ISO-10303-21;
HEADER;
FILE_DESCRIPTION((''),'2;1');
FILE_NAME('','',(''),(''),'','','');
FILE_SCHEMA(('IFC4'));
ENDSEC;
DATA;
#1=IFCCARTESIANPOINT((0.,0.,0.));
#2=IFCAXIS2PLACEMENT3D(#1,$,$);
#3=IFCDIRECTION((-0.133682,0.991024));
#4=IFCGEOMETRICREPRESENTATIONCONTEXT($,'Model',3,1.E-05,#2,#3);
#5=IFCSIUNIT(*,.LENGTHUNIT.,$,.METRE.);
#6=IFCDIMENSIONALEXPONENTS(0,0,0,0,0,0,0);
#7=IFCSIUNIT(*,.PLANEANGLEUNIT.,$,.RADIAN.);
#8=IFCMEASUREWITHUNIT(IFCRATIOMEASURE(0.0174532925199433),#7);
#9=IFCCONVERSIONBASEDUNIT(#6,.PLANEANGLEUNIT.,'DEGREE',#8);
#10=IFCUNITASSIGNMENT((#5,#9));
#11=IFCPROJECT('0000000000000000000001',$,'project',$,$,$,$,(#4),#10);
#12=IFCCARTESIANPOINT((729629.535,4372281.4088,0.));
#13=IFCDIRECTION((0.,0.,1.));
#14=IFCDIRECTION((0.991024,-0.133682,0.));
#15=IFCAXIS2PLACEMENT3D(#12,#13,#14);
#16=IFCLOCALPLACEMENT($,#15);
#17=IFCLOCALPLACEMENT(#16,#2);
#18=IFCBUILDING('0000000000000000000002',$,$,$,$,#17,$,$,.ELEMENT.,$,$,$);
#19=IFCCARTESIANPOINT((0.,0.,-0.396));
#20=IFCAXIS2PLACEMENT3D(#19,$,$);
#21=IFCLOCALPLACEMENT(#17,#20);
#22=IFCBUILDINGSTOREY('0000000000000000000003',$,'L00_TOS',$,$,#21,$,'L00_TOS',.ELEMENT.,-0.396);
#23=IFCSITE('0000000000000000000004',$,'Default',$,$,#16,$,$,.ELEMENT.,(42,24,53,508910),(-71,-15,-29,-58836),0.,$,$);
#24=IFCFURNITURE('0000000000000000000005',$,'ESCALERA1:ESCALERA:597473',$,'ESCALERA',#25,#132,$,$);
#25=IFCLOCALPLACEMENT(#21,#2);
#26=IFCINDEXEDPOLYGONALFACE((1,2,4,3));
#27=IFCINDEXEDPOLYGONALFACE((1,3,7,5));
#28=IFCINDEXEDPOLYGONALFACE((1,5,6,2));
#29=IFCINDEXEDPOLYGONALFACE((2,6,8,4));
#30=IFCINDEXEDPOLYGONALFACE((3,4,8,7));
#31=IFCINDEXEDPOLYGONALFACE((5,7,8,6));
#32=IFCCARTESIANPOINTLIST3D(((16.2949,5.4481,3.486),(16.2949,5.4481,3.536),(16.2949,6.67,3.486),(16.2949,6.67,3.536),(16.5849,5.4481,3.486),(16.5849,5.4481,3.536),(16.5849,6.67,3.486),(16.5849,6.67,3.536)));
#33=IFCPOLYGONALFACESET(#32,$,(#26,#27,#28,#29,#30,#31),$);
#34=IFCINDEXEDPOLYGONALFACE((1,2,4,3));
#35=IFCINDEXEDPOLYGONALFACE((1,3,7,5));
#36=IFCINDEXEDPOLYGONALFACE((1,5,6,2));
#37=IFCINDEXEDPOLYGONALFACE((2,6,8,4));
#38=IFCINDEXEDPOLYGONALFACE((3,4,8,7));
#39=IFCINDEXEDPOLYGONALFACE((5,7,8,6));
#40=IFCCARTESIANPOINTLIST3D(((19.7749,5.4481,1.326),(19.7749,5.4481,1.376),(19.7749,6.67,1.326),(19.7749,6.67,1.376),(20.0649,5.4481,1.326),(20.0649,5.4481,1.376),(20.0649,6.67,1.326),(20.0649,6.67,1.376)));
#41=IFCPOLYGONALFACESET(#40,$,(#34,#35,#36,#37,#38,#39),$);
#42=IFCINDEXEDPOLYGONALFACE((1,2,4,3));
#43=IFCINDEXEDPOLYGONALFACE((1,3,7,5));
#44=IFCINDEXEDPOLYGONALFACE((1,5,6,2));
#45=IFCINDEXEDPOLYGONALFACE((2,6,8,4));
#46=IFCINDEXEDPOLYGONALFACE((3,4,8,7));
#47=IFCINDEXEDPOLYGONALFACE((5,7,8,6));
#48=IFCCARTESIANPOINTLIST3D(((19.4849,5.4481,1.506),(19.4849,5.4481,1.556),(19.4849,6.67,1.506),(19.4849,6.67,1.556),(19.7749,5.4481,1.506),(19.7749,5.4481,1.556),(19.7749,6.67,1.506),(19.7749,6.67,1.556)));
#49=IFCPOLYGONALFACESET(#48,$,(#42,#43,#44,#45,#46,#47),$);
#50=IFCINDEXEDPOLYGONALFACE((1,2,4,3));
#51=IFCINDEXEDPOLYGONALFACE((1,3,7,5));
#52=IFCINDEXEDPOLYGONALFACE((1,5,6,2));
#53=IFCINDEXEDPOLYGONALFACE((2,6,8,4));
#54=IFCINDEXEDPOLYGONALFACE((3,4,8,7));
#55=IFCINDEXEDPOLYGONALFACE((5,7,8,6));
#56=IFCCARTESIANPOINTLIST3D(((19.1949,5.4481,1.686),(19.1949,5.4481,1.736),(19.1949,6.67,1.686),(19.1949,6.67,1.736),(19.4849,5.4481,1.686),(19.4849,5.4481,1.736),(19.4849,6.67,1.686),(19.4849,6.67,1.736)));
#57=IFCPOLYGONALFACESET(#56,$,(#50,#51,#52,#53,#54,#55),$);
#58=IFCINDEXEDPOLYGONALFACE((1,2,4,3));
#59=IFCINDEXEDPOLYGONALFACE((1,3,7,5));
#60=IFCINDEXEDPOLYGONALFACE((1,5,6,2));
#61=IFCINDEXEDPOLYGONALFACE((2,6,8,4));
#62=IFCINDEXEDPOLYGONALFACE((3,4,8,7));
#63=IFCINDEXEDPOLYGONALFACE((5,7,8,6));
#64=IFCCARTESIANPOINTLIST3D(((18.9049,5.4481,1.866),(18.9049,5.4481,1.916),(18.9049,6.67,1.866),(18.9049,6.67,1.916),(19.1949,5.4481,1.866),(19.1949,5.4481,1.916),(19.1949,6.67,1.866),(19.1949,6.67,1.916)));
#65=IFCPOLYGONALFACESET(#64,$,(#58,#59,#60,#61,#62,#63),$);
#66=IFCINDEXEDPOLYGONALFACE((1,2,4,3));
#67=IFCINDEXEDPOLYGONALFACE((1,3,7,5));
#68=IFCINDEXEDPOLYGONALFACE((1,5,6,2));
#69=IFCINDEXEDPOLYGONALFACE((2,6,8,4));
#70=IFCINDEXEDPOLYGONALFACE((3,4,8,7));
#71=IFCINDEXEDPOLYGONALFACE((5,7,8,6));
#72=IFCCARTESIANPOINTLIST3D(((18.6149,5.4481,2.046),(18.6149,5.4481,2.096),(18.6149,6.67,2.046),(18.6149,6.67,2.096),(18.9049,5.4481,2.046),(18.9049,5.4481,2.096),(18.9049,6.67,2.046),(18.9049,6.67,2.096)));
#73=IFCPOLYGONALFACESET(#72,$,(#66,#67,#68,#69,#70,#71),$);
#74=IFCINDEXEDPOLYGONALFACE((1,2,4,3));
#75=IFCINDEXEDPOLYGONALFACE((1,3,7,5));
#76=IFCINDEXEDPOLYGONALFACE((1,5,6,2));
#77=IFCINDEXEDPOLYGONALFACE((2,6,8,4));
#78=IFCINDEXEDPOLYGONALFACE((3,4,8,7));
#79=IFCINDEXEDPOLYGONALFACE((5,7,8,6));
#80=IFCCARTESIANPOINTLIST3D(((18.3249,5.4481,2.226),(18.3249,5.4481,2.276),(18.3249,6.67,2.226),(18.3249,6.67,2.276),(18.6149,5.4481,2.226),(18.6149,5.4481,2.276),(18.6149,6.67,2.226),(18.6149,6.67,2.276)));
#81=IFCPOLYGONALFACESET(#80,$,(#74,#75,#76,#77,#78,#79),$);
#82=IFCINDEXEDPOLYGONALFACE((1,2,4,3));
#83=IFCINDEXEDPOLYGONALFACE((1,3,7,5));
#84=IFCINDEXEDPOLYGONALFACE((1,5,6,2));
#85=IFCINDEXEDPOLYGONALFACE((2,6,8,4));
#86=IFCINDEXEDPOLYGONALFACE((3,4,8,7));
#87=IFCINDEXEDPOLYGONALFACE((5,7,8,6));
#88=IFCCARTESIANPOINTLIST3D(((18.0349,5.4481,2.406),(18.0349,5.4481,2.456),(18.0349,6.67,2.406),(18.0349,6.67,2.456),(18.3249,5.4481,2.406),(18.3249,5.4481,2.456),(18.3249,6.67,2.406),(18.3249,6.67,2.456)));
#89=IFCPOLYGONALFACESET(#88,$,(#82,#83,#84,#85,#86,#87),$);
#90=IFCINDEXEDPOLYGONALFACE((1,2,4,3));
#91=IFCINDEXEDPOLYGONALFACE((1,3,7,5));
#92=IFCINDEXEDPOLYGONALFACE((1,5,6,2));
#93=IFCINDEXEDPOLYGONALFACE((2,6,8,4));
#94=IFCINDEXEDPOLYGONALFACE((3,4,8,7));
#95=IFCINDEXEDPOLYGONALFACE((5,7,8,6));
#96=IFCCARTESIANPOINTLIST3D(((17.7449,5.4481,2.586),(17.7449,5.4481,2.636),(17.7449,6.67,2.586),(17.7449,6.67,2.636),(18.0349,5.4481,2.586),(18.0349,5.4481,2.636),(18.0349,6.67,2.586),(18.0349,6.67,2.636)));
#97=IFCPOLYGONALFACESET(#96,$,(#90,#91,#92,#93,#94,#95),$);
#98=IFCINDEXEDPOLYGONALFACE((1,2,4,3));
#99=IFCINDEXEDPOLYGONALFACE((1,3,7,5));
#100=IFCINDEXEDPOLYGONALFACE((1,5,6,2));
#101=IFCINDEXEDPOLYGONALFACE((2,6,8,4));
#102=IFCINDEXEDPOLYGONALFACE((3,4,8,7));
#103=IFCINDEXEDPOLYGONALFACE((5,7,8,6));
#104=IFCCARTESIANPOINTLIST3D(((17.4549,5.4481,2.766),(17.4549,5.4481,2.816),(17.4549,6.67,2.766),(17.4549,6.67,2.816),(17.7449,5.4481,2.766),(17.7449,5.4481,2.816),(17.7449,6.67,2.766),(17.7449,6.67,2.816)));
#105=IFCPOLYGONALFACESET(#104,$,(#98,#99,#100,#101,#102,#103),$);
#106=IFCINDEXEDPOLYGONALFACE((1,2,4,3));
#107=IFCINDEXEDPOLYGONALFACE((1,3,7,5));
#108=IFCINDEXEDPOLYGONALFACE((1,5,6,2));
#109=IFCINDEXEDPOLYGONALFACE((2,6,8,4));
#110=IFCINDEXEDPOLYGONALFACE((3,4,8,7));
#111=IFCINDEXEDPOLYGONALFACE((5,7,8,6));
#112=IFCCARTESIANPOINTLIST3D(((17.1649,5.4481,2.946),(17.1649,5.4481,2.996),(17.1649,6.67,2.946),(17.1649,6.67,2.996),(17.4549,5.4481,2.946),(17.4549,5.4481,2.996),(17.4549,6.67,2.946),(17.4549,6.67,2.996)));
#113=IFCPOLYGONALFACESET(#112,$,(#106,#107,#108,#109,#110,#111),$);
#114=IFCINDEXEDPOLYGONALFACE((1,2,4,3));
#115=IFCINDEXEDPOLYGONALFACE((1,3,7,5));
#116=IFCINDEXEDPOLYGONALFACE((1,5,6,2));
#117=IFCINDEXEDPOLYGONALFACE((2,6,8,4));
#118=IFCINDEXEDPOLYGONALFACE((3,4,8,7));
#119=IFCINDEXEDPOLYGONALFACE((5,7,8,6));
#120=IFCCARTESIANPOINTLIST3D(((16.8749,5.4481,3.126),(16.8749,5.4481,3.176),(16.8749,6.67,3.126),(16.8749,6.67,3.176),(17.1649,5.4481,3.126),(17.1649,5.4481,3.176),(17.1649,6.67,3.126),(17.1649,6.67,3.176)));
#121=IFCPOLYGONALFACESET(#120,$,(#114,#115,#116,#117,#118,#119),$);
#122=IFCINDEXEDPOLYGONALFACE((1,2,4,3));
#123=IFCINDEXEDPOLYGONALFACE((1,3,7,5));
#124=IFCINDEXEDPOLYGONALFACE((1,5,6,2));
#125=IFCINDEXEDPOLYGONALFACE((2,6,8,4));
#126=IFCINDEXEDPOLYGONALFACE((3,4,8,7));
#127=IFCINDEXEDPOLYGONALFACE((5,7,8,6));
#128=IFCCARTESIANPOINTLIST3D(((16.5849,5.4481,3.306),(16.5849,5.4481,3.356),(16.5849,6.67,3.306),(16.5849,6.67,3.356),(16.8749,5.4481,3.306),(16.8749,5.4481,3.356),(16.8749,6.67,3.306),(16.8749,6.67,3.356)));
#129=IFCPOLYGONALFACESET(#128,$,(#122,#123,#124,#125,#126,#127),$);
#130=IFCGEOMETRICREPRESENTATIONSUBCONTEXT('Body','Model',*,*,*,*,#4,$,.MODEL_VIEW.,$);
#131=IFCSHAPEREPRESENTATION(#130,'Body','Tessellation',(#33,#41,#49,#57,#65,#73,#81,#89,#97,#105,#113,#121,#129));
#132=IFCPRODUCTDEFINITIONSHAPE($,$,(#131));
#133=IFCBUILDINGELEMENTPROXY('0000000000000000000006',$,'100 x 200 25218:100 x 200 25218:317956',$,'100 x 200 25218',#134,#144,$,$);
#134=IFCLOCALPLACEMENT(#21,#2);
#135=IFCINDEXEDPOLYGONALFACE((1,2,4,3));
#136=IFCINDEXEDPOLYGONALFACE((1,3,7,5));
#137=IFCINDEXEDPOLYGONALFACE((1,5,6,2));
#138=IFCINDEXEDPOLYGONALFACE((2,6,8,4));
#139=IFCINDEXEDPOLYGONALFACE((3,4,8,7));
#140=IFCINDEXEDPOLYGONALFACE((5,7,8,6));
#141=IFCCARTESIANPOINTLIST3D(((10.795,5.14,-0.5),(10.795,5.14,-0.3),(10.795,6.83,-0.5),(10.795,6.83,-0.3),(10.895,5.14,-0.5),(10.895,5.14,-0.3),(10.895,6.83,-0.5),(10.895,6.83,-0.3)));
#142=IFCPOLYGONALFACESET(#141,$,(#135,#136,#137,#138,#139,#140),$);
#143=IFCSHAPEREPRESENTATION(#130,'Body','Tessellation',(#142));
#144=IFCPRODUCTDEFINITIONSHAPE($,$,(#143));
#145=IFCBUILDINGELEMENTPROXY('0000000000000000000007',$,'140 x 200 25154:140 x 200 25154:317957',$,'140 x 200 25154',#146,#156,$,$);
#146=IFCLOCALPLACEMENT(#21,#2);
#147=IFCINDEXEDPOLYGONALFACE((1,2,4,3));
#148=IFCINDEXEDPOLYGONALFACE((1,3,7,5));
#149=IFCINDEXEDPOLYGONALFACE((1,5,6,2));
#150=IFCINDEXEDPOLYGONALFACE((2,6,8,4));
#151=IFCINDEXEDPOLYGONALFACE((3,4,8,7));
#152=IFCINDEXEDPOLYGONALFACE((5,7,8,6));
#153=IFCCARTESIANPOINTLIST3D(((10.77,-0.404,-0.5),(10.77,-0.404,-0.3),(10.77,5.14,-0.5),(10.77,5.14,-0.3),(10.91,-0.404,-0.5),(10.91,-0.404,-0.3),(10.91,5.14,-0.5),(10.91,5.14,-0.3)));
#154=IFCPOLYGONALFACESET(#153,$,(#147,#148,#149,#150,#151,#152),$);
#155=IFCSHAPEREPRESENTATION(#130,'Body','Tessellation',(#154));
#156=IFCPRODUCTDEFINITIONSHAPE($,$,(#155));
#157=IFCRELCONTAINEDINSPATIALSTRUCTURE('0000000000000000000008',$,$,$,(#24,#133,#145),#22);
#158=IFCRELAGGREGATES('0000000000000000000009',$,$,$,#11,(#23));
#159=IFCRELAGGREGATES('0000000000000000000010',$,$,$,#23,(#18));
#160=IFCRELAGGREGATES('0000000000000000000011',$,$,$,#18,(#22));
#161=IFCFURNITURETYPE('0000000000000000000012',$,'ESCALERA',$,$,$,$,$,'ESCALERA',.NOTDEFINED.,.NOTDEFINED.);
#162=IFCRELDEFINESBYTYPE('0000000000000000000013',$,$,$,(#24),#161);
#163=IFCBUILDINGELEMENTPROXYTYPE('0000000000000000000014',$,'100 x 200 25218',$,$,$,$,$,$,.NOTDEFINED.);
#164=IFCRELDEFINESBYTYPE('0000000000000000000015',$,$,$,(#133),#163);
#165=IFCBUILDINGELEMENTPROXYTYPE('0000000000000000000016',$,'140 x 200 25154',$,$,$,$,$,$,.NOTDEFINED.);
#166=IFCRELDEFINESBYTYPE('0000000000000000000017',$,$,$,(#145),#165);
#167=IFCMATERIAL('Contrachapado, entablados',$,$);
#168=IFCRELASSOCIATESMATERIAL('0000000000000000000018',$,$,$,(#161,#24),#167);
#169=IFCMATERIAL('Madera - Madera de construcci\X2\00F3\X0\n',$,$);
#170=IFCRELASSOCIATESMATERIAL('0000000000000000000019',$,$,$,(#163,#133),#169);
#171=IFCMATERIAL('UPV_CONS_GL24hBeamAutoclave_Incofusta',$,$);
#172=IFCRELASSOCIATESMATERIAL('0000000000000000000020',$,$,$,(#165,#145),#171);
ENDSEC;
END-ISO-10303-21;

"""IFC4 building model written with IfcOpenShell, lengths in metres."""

from ifc_helpers import new_model, entity, si_unit, converted_unit, direction, frame, frame_2d, origin, origin_2d_with_axis, place, context, subcontext, project, spatial, rectangle, extrude, source, transform, mapped, material, type_object, type_shapes, element, save


model = new_model("IFC4")

# Units and contexts
model_context = context("Model", 3, precision=1e-05, world=origin(), true_north=direction((-0.133682, 0.991024)))
body_context = subcontext(model_context, "Body", "Model", "MODEL_VIEW")
ifc_project = project(units=[si_unit("LENGTHUNIT", "METRE"), converted_unit("PLANEANGLEUNIT", "DEGREE", entity("IfcRatioMeasure", 0.0174532925199433), si_unit("PLANEANGLEUNIT", "RADIAN"), dimensions=[0, 0, 0, 0, 0, 0, 0])], contexts=[model_context])

# Site, building, storey
site_placement = place(None, frame((729629.535, 4372281.4088, 0.0), z_axis=(0.0, 0.0, 1.0), x_axis=(0.991024, -0.133682, 0.0)))
site = spatial("IfcSite", under=ifc_project, at=site_placement, Name="Default", CompositionType="ELEMENT", RefLatitude=(42, 24, 53, 508910), RefLongitude=(-71, -15, -29, -58836), RefElevation=0.0)
building_placement = place(site_placement, origin())
building = spatial("IfcBuilding", under=site, at=building_placement, CompositionType="ELEMENT")
storey_placement = place(building_placement, frame((0.0, 0.0, -0.396)))
storey = spatial("IfcBuildingStorey", under=building, at=storey_placement, Name="L00_TOS", LongName="L00_TOS", CompositionType="ELEMENT", Elevation=-0.396)

# Shared definitions
ifc_material_1 = material(Name="Madera - Madera de construcción")

# Furniture
ifc_material_2 = material(Name="Contrachapado, entablados")
furniture_type_1 = type_object("IfcFurnitureType", Name="ESCALERA", ElementType="ESCALERA", material=ifc_material_2)
shared_shape_1 = source(origin(), body_context, "Body", "SweptSolid", [
    extrude(rectangle(XDim=1.2219, YDim=0.29, at=origin_2d_with_axis()), frame((0.145, 0.611, 2.16), z_axis=(0.0, 0.0, 1.0), x_axis=(0.0, -1.0, 0.0)), (0.0, 0.0, 1.0), 0.05),
    extrude(rectangle(XDim=1.2219, YDim=0.29, at=origin_2d_with_axis()), frame((3.625, 0.611, 0.0), z_axis=(0.0, 0.0, 1.0), x_axis=(0.0, -1.0, 0.0)), (0.0, 0.0, 1.0), 0.05),
    extrude(rectangle(XDim=1.2219, YDim=0.29, at=frame_2d((0.0, 0.0), x_axis=(1.0, 0.0))), frame((3.335, 0.611, 0.18), z_axis=(0.0, 0.0, 1.0), x_axis=(0.0, -1.0, 0.0)), (0.0, 0.0, 1.0), 0.05),
    extrude(rectangle(XDim=1.2219, YDim=0.29, at=origin_2d_with_axis()), frame((3.045, 0.611, 0.36), z_axis=(0.0, 0.0, 1.0), x_axis=(0.0, -1.0, 0.0)), (0.0, 0.0, 1.0), 0.05),
    extrude(rectangle(XDim=1.2219, YDim=0.29, at=origin_2d_with_axis()), frame((2.755, 0.611, 0.54), z_axis=(0.0, 0.0, 1.0), x_axis=(0.0, -1.0, 0.0)), (0.0, 0.0, 1.0), 0.05),
    extrude(rectangle(XDim=1.2219, YDim=0.29, at=origin_2d_with_axis()), frame((2.465, 0.611, 0.72), z_axis=(0.0, 0.0, 1.0), x_axis=(0.0, -1.0, 0.0)), (0.0, 0.0, 1.0), 0.05),
    extrude(rectangle(XDim=1.2219, YDim=0.29, at=origin_2d_with_axis()), frame((2.175, 0.611, 0.9), z_axis=(0.0, 0.0, 1.0), x_axis=(0.0, -1.0, 0.0)), (0.0, 0.0, 1.0), 0.05),
    extrude(rectangle(XDim=1.2219, YDim=0.29, at=origin_2d_with_axis()), frame((1.885, 0.611, 1.08), z_axis=(0.0, 0.0, 1.0), x_axis=(0.0, -1.0, 0.0)), (0.0, 0.0, 1.0), 0.05),
    extrude(rectangle(XDim=1.2219, YDim=0.29, at=origin_2d_with_axis()), frame((1.595, 0.611, 1.26), z_axis=(0.0, 0.0, 1.0), x_axis=(0.0, -1.0, 0.0)), (0.0, 0.0, 1.0), 0.05),
    extrude(rectangle(XDim=1.2219, YDim=0.29, at=origin_2d_with_axis()), frame((1.305, 0.611, 1.44), z_axis=(0.0, 0.0, 1.0), x_axis=(0.0, -1.0, 0.0)), (0.0, 0.0, 1.0), 0.05),
    extrude(rectangle(XDim=1.2219, YDim=0.29, at=origin_2d_with_axis()), frame((1.015, 0.611, 1.62), z_axis=(0.0, 0.0, 1.0), x_axis=(0.0, -1.0, 0.0)), (0.0, 0.0, 1.0), 0.05),
    extrude(rectangle(XDim=1.2219, YDim=0.29, at=origin_2d_with_axis()), frame((0.725, 0.611, 1.8), z_axis=(0.0, 0.0, 1.0), x_axis=(0.0, -1.0, 0.0)), (0.0, 0.0, 1.0), 0.05),
    extrude(rectangle(XDim=1.2219, YDim=0.29, at=origin_2d_with_axis()), frame((0.435, 0.611, 1.98), z_axis=(0.0, 0.0, 1.0), x_axis=(0.0, -1.0, 0.0)), (0.0, 0.0, 1.0), 0.05),
])
type_shapes(furniture_type_1, [shared_shape_1])
furniture_1_placement = place(storey_placement, frame((16.2949, 5.4481, 1.326)))
element("IfcFurniture", 1, at=furniture_1_placement, inside=storey, type_object=furniture_type_1, material=ifc_material_2, Name="ESCALERA1:ESCALERA:597473", ObjectType="ESCALERA", context=body_context, shape_type="MappedRepresentation", body=[
    mapped(shared_shape_1, transform((0.0, 0.0, 0.0), scale=1.0)),
])

# Building element proxies
building_element_proxy_type_1 = type_object("IfcBuildingElementProxyType", Name="100 x 200 25218", material=ifc_material_1)
shared_shape_2 = source(origin(), body_context, "Body", "SweptSolid", [
    extrude(rectangle(XDim=0.1, YDim=1.69, at=origin_2d_with_axis()), frame((-0.065, 0.0, -0.1), z_axis=(0.0, 0.0, 1.0), x_axis=(0.0, -1.0, 0.0)), (0.0, 0.0, 1.0), 0.2),
])
type_shapes(building_element_proxy_type_1, [shared_shape_2])
proxy_1_placement = place(storey_placement, frame((10.845, 6.05, -0.4), z_axis=(0.0, 0.0, 1.0), x_axis=(0.0, 1.0, 0.0)))
element("IfcBuildingElementProxy", 2, at=proxy_1_placement, inside=storey, type_object=building_element_proxy_type_1, material=ifc_material_1, Name="100 x 200 25218:100 x 200 25218:317956", ObjectType="100 x 200 25218", context=body_context, shape_type="MappedRepresentation", body=[
    mapped(shared_shape_2, transform((0.0, 0.0, 0.0), scale=1.0)),
])
ifc_material_3 = material(Name="UPV_CONS_GL24hBeamAutoclave_Incofusta")
building_element_proxy_type_2 = type_object("IfcBuildingElementProxyType", Name="140 x 200 25154", material=ifc_material_3)
shared_shape_3 = source(origin(), body_context, "Body", "SweptSolid", [
    extrude(rectangle(XDim=0.14, YDim=5.544, at=origin_2d_with_axis()), frame((-0.042, 0.0, -0.1), z_axis=(0.0, 0.0, 1.0), x_axis=(0.0, -1.0, 0.0)), (0.0, 0.0, 1.0), 0.2),
])
type_shapes(building_element_proxy_type_2, [shared_shape_3])
proxy_2_placement = place(storey_placement, frame((10.84, 2.41, -0.4), z_axis=(0.0, 0.0, 1.0), x_axis=(0.0, 1.0, 0.0)))
element("IfcBuildingElementProxy", 3, at=proxy_2_placement, inside=storey, type_object=building_element_proxy_type_2, material=ifc_material_3, Name="140 x 200 25154:140 x 200 25154:317957", ObjectType="140 x 200 25154", context=body_context, shape_type="MappedRepresentation", body=[
    mapped(shared_shape_3, transform((0.0, 0.0, 0.0), scale=1.0)),
])

save(model, "model.ifc")
